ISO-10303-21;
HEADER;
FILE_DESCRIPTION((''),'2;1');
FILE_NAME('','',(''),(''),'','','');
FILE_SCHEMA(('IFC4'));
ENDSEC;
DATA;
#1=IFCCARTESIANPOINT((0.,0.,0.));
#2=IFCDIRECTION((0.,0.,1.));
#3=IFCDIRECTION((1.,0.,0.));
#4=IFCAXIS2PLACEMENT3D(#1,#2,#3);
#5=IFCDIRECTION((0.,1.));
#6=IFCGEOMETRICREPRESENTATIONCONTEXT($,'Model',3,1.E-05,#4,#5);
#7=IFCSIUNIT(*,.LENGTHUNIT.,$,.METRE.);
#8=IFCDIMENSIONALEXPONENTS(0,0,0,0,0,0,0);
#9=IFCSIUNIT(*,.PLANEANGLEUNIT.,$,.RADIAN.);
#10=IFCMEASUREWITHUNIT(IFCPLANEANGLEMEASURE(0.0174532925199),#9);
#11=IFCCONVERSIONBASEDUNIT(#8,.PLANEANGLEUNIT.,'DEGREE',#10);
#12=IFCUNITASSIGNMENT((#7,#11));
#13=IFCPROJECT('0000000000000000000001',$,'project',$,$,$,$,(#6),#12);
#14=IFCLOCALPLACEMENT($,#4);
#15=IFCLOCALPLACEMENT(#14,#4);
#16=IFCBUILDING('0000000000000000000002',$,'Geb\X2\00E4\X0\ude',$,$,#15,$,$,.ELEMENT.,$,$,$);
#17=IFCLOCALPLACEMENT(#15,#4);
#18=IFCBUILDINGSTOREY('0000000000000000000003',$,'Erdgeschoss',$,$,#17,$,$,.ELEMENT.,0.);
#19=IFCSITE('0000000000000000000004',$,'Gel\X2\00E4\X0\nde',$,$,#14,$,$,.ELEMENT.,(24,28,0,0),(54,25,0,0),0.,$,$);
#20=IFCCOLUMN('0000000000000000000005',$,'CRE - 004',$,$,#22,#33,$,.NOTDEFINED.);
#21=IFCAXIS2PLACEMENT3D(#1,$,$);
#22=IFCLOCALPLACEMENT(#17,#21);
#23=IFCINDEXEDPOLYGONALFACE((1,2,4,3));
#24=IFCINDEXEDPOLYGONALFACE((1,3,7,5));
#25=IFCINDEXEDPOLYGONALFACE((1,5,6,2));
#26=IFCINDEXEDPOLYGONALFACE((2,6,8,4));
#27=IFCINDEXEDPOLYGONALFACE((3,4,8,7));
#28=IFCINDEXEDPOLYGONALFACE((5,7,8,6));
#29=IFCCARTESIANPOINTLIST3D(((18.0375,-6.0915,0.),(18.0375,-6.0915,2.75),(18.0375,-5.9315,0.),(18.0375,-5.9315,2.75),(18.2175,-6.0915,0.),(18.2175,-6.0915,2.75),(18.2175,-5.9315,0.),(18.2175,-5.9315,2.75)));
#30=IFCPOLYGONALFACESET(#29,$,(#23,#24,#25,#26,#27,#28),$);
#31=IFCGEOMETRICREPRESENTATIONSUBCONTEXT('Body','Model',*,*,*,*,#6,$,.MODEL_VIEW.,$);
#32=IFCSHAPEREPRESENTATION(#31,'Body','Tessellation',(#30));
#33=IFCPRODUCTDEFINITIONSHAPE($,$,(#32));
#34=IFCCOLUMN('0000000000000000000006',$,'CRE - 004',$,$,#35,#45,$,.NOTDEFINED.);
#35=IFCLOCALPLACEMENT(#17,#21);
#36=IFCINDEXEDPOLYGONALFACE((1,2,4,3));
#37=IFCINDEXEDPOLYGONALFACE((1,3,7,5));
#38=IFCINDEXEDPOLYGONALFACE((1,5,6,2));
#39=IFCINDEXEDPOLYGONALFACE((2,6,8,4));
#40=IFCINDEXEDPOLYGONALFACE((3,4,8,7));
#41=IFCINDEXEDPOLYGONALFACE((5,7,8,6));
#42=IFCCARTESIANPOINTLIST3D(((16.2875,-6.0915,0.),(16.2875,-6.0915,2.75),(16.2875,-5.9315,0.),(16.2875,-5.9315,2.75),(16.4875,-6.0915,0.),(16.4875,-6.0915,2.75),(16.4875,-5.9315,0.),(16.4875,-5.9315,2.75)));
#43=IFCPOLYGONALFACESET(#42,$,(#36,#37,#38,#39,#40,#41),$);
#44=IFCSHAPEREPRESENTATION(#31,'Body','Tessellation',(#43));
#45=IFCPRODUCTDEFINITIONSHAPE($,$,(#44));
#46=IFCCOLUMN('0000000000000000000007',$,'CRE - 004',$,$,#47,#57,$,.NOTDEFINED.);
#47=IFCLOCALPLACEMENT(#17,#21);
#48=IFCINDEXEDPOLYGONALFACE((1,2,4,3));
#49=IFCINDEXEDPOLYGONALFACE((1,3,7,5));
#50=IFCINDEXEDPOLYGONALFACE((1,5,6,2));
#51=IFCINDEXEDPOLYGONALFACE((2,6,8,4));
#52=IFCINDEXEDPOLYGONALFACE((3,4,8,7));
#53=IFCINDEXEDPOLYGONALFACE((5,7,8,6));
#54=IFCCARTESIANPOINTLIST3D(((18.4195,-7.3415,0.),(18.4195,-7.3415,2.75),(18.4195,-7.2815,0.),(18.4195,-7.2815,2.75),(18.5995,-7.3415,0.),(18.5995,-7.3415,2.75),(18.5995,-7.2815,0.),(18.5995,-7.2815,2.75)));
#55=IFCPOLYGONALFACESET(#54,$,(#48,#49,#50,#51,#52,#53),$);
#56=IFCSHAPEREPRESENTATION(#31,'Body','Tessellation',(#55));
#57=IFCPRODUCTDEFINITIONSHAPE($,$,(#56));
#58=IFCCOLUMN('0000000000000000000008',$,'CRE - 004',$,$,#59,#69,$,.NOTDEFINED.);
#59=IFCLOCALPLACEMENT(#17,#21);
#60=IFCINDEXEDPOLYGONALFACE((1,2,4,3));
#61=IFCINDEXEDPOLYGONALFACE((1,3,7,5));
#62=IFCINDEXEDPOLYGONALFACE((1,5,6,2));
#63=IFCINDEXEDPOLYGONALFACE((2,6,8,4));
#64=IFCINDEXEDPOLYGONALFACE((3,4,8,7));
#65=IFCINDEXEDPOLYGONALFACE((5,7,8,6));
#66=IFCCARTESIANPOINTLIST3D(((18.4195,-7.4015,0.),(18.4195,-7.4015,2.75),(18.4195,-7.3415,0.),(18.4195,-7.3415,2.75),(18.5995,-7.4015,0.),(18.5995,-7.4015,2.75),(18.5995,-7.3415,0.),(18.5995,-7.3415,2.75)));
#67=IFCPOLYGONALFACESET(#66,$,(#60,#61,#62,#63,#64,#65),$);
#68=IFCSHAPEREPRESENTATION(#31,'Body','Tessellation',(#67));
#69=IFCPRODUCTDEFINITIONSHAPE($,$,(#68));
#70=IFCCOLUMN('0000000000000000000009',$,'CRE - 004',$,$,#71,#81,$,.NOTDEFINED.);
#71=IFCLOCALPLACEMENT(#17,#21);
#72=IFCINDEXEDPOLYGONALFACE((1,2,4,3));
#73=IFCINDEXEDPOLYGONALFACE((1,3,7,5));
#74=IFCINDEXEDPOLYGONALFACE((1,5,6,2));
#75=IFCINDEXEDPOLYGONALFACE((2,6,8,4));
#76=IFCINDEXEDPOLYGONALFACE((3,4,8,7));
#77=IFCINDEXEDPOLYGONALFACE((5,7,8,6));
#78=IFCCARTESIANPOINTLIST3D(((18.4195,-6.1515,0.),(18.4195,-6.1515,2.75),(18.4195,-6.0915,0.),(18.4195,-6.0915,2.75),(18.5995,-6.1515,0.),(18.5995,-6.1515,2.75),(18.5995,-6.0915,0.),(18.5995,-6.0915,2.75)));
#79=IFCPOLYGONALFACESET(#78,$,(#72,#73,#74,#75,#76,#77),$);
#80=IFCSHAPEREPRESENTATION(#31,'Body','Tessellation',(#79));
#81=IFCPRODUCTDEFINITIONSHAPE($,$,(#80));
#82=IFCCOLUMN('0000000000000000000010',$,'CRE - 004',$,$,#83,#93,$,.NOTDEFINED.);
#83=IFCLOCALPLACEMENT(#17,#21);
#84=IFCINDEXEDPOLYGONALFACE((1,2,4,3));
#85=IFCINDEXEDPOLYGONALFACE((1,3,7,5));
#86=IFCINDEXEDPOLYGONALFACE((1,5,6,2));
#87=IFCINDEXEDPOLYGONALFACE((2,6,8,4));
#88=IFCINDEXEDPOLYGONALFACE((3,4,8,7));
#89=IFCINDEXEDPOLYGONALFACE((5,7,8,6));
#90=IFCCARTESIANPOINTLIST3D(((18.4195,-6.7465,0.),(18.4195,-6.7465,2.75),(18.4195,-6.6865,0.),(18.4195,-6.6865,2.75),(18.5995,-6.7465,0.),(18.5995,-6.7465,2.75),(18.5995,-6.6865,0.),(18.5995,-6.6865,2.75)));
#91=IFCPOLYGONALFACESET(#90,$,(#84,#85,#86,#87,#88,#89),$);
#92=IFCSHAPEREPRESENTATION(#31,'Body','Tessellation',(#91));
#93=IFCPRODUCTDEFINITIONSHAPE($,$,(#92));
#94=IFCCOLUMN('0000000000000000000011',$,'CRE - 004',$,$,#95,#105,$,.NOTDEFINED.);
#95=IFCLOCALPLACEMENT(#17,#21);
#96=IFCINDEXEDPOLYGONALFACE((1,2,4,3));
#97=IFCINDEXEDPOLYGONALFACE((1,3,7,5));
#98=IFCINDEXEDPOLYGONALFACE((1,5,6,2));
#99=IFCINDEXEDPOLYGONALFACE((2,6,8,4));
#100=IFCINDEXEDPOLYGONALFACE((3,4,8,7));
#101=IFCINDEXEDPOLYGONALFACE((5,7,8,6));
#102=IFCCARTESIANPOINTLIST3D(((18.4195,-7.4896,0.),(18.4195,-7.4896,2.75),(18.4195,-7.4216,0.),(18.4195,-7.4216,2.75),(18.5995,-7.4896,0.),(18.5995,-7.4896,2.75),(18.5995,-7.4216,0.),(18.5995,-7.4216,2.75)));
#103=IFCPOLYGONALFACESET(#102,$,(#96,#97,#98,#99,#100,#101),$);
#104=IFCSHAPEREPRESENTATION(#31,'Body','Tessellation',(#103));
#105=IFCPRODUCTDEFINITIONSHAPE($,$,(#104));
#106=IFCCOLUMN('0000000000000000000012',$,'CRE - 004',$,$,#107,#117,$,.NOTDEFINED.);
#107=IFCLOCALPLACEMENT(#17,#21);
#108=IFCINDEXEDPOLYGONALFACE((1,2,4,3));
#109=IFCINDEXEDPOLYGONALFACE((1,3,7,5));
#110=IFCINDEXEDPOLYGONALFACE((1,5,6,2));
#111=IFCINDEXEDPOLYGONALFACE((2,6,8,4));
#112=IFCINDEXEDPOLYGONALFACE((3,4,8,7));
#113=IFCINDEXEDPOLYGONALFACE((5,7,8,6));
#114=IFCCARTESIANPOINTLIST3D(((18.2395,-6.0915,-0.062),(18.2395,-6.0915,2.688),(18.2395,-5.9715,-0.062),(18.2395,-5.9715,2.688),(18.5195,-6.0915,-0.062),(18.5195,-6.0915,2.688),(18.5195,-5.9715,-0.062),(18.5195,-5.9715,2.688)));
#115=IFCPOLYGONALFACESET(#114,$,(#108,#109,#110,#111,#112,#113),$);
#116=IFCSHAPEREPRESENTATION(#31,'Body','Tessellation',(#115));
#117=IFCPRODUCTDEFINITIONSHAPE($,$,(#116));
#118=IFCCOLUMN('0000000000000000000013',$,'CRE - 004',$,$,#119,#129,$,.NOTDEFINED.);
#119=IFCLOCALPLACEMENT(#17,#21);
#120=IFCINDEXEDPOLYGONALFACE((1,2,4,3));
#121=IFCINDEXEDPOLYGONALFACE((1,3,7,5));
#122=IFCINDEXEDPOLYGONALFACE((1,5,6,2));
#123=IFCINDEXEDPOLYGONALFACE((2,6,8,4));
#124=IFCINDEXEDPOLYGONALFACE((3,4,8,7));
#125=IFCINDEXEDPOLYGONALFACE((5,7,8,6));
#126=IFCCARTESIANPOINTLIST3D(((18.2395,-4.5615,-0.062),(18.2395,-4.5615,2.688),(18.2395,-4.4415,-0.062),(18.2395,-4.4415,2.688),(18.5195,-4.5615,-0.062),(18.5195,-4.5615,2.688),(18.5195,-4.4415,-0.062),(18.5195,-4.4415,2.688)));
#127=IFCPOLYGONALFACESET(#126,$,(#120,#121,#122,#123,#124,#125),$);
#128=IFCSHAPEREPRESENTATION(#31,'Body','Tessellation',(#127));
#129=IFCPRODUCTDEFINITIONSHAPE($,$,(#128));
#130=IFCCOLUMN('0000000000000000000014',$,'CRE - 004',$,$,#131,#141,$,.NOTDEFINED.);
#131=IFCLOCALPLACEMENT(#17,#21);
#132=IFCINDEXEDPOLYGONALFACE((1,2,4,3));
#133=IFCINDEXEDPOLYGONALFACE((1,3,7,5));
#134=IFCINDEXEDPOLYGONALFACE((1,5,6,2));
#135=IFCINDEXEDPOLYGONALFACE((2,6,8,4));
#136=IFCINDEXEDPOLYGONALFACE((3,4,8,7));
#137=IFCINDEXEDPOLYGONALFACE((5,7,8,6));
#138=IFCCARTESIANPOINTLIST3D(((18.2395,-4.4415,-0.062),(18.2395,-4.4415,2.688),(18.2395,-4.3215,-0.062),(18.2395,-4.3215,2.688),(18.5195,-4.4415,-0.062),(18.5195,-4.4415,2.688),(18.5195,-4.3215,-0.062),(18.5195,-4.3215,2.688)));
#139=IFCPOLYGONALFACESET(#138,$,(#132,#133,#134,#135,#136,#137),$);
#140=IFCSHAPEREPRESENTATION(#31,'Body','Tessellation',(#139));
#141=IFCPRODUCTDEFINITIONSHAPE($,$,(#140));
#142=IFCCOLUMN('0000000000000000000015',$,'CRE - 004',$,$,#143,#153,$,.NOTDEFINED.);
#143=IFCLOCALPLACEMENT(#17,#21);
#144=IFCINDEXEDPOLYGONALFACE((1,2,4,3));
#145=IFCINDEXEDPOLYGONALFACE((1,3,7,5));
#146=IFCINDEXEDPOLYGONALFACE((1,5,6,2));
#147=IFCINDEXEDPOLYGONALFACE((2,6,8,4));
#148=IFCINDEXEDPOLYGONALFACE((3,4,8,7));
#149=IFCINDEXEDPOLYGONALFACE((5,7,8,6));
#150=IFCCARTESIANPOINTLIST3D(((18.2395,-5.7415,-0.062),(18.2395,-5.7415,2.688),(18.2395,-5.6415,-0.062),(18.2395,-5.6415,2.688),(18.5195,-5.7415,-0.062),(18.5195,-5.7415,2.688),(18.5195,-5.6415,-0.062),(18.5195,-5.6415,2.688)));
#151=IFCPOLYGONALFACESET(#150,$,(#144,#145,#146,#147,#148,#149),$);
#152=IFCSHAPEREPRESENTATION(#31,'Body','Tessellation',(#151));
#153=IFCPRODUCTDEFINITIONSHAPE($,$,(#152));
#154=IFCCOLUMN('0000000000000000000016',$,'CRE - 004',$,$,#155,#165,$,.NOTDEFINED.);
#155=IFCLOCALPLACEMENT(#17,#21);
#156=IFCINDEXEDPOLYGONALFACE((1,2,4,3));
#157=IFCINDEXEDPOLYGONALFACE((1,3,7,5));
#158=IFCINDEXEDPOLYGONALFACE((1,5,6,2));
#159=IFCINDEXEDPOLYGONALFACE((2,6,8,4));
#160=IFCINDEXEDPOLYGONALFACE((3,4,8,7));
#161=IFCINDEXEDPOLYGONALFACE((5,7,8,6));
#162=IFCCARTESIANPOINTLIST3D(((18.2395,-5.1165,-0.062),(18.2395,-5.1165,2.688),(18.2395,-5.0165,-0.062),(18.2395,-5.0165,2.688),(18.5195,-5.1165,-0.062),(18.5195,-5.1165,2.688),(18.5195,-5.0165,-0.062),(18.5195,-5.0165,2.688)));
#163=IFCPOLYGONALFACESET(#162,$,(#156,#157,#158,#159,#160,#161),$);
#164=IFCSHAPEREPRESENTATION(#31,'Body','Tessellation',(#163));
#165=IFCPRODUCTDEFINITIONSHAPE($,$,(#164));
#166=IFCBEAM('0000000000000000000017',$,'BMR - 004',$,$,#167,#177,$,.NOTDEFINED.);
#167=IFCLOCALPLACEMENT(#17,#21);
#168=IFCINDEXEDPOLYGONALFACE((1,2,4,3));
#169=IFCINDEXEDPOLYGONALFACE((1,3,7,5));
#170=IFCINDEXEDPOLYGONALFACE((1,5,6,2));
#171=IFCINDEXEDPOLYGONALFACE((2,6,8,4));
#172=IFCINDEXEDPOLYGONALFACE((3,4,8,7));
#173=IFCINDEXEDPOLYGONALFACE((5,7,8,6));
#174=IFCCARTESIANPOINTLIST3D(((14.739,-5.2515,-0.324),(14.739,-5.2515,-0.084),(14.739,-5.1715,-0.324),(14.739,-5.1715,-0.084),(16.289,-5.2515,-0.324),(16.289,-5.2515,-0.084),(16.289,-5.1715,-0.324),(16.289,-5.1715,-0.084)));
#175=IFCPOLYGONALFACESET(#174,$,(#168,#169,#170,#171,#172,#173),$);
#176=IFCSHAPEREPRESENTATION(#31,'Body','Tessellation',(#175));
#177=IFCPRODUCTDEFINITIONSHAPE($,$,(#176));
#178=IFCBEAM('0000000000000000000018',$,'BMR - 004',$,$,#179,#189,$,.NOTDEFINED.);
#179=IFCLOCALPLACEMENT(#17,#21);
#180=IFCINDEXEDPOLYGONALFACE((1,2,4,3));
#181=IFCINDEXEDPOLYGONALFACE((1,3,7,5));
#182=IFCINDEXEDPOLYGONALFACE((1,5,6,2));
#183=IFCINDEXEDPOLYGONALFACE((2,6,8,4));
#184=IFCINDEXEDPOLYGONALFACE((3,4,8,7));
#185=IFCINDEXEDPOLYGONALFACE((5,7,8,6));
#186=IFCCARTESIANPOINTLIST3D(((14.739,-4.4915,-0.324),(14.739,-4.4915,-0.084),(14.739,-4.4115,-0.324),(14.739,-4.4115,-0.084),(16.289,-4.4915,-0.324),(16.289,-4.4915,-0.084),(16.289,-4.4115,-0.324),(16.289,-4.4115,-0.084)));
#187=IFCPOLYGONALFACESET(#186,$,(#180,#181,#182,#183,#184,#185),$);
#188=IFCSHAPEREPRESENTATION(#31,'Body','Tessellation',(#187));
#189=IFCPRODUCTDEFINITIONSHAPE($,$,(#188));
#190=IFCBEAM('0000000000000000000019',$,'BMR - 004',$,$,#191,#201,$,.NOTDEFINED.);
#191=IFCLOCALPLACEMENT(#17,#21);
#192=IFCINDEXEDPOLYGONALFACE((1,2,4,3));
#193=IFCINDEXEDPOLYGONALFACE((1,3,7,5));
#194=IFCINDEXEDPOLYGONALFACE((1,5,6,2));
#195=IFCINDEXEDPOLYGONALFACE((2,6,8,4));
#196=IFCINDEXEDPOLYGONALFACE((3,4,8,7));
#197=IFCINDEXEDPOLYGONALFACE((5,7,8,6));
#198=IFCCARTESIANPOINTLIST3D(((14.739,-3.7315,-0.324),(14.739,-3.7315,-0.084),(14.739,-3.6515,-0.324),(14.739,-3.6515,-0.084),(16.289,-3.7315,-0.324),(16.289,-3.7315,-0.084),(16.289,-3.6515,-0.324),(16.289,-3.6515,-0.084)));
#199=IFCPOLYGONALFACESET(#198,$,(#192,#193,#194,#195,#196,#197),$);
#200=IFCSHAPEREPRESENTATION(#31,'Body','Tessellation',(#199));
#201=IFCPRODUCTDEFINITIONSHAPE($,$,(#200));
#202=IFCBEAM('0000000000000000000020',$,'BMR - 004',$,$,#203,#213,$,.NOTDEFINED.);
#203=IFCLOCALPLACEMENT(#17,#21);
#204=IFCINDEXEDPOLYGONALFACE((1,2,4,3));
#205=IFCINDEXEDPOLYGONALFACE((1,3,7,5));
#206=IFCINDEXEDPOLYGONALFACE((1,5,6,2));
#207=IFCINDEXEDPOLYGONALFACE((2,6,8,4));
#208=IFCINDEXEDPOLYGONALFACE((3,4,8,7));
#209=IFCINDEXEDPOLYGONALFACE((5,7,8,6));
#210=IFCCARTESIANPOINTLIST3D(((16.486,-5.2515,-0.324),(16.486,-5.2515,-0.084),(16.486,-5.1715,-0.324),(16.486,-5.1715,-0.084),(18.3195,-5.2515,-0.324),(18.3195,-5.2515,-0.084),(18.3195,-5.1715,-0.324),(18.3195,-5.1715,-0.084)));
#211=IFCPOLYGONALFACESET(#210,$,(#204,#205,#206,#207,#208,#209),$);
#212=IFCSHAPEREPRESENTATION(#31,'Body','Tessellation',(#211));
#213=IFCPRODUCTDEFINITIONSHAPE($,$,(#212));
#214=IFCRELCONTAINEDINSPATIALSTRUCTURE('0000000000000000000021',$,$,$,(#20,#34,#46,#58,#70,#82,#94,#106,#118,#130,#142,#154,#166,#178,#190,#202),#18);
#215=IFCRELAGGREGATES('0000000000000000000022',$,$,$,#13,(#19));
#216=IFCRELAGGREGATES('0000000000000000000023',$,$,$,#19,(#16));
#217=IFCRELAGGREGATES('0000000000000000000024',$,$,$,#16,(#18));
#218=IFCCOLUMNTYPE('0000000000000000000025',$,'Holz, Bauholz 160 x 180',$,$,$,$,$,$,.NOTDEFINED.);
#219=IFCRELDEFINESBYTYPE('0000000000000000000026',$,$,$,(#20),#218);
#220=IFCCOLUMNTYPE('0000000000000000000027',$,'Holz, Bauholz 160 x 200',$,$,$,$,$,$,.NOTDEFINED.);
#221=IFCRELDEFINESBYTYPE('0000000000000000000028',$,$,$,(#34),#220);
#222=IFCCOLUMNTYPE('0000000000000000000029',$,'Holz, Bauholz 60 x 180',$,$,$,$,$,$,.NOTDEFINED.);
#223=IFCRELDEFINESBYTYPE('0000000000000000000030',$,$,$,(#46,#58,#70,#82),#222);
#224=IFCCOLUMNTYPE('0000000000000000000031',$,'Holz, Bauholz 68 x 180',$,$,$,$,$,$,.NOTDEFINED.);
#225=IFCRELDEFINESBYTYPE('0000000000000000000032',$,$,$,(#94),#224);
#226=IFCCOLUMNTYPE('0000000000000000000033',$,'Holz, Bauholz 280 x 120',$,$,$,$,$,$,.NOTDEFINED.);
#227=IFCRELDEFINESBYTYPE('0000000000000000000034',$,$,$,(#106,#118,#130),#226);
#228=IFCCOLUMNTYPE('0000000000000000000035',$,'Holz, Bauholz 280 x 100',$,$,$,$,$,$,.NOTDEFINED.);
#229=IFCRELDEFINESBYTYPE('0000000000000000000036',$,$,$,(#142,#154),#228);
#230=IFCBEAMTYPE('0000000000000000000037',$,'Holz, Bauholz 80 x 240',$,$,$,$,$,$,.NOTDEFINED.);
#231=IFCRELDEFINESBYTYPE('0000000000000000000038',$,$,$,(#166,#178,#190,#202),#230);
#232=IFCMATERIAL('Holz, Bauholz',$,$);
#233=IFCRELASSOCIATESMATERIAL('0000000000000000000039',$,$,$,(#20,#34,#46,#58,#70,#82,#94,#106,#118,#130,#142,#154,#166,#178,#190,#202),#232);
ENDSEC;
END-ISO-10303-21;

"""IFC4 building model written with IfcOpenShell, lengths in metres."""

from ifc_helpers import new_model, entity, si_unit, converted_unit, direction, frame, frame_2d, origin_with_axes, origin_2d_with_axis, place, context, subcontext, project, spatial, rectangle, extrude, material, type_object, element, save


model = new_model("IFC4")

# Units and contexts
model_context = context("Model", 3, precision=1e-05, world=origin_with_axes(), true_north=direction((0.0, 1.0)))
body_context = subcontext(model_context, "Body", "Model", "MODEL_VIEW")
ifc_project = project(units=[si_unit("LENGTHUNIT", "METRE"), converted_unit("PLANEANGLEUNIT", "DEGREE", entity("IfcPlaneAngleMeasure", 0.0174532925199), si_unit("PLANEANGLEUNIT", "RADIAN"), dimensions=[0, 0, 0, 0, 0, 0, 0])], contexts=[model_context])

# Site, building, storey
site_placement = place(None, origin_with_axes())
site = spatial("IfcSite", under=ifc_project, at=site_placement, Name="Gelände", CompositionType="ELEMENT", RefLatitude=(24, 28, 0, 0), RefLongitude=(54, 25, 0, 0), RefElevation=0.0)
building_placement = place(site_placement, origin_with_axes())
building = spatial("IfcBuilding", under=site, at=building_placement, Name="Gebäude", CompositionType="ELEMENT")
storey_placement = place(building_placement, origin_with_axes())
storey = spatial("IfcBuildingStorey", under=building, at=storey_placement, Name="Erdgeschoss", CompositionType="ELEMENT", Elevation=0.0)

# Columns
ifc_material_1 = material(Name="Holz, Bauholz")
column_type_1 = type_object("IfcColumnType", Name="Holz, Bauholz 160 x 180", PredefinedType="NOTDEFINED")
column_1_placement = place(storey_placement, frame((18.1275, -6.0115, 0.0), z_axis=(0.0, 0.0, 1.0), x_axis=(1.0, 0.0, 0.0)))
element("IfcColumn", 1, at=column_1_placement, inside=storey, type_object=column_type_1, material=ifc_material_1, Name="CRE - 004", PredefinedType="NOTDEFINED", context=body_context, shape_type="SweptSolid", body=[
    extrude(rectangle(XDim=0.16, YDim=0.18, at=origin_2d_with_axis()), frame((0.0, 0.0, 0.0), z_axis=(0.0, 0.0, 1.0), x_axis=(0.0, 1.0, 0.0)), (0.0, 0.0, 1.0), 2.75),
])
column_type_2 = type_object("IfcColumnType", Name="Holz, Bauholz 160 x 200", PredefinedType="NOTDEFINED")
column_2_placement = place(storey_placement, frame((16.3875, -6.0115, 0.0), z_axis=(0.0, 0.0, 1.0), x_axis=(1.0, 0.0, 0.0)))
element("IfcColumn", 2, at=column_2_placement, inside=storey, type_object=column_type_2, material=ifc_material_1, Name="CRE - 004", PredefinedType="NOTDEFINED", context=body_context, shape_type="SweptSolid", body=[
    extrude(rectangle(XDim=0.16, YDim=0.2, at=origin_2d_with_axis()), frame((0.0, 0.0, 0.0), z_axis=(0.0, 0.0, 1.0), x_axis=(0.0, 1.0, 0.0)), (0.0, 0.0, 1.0), 2.75),
])
column_type_3 = type_object("IfcColumnType", Name="Holz, Bauholz 60 x 180", PredefinedType="NOTDEFINED")
for number, where, z_axis, x_axis, name in (
    (3, (18.5095, -7.3115, 0.0), (0.0, 0.0, 1.0), (1.0, 0.0, 0.0), "CRE - 004"),
    (4, (18.5095, -7.3715, 0.0), (0.0, 0.0, 1.0), (1.0, 0.0, 0.0), "CRE - 004"),
    (5, (18.5095, -6.1215, 0.0), (0.0, 0.0, 1.0), (1.0, 0.0, 0.0), "CRE - 004"),
    (6, (18.5095, -6.7165, 0.0), (0.0, 0.0, 1.0), (1.0, 0.0, 0.0), "CRE - 004"),
):
    element("IfcColumn", number, at=place(storey_placement, frame(where, z_axis=z_axis, x_axis=x_axis)), inside=storey, type_object=column_type_3, material=ifc_material_1, Name=name, PredefinedType="NOTDEFINED", context=body_context, shape_type="SweptSolid", body=[
        extrude(rectangle(XDim=0.06, YDim=0.18, at=origin_2d_with_axis()), frame((0.0, 0.0, 0.0), z_axis=(0.0, 0.0, 1.0), x_axis=(0.0, 1.0, 0.0)), (0.0, 0.0, 1.0), 2.75),
    ])
column_type_4 = type_object("IfcColumnType", Name="Holz, Bauholz 68 x 180", PredefinedType="NOTDEFINED")
column_3_placement = place(storey_placement, frame((18.5095, -7.4556, 0.0), z_axis=(0.0, 0.0, 1.0), x_axis=(1.0, 0.0, 0.0)))
element("IfcColumn", 7, at=column_3_placement, inside=storey, type_object=column_type_4, material=ifc_material_1, Name="CRE - 004", PredefinedType="NOTDEFINED", context=body_context, shape_type="SweptSolid", body=[
    extrude(rectangle(XDim=0.068, YDim=0.18, at=origin_2d_with_axis()), frame((0.0, 0.0, 0.0), z_axis=(0.0, 0.0, 1.0), x_axis=(0.0, 1.0, 0.0)), (0.0, 0.0, 1.0), 2.75),
])
column_type_5 = type_object("IfcColumnType", Name="Holz, Bauholz 280 x 120", PredefinedType="NOTDEFINED")
for number, where, z_axis, x_axis, name in (
    (8, (18.3795, -6.0315, -0.062), (0.0, 0.0, 1.0), (0.0, 1.0, 0.0), "CRE - 004"),
    (9, (18.3795, -4.5015, -0.062), (0.0, 0.0, 1.0), (0.0, 1.0, 0.0), "CRE - 004"),
    (10, (18.3795, -4.3815, -0.062), (0.0, 0.0, 1.0), (0.0, 1.0, 0.0), "CRE - 004"),
):
    element("IfcColumn", number, at=place(storey_placement, frame(where, z_axis=z_axis, x_axis=x_axis)), inside=storey, type_object=column_type_5, material=ifc_material_1, Name=name, PredefinedType="NOTDEFINED", context=body_context, shape_type="SweptSolid", body=[
        extrude(rectangle(XDim=0.28, YDim=0.12, at=origin_2d_with_axis()), frame((0.0, 0.0, 0.0), z_axis=(0.0, 0.0, 1.0), x_axis=(0.0, 1.0, 0.0)), (0.0, 0.0, 1.0), 2.75),
    ])
column_type_6 = type_object("IfcColumnType", Name="Holz, Bauholz 280 x 100", PredefinedType="NOTDEFINED")
for number, where, z_axis, x_axis, name in (
    (11, (18.3795, -5.6915, -0.062), (0.0, 0.0, 1.0), (0.0, 1.0, 0.0), "CRE - 004"),
    (12, (18.3795, -5.0665, -0.062), (0.0, 0.0, 1.0), (0.0, 1.0, 0.0), "CRE - 004"),
):
    element("IfcColumn", number, at=place(storey_placement, frame(where, z_axis=z_axis, x_axis=x_axis)), inside=storey, type_object=column_type_6, material=ifc_material_1, Name=name, PredefinedType="NOTDEFINED", context=body_context, shape_type="SweptSolid", body=[
        extrude(rectangle(XDim=0.28, YDim=0.1, at=origin_2d_with_axis()), frame((0.0, 0.0, 0.0), z_axis=(0.0, 0.0, 1.0), x_axis=(0.0, 1.0, 0.0)), (0.0, 0.0, 1.0), 2.75),
    ])

# Beams
beam_type_1 = type_object("IfcBeamType", Name="Holz, Bauholz 80 x 240", PredefinedType="NOTDEFINED")
for number, where, z_axis, x_axis, name in (
    (13, (16.289, -5.2115, -0.084), (0.0, 0.0, 1.0), (0.0, 1.0, 0.0), "BMR - 004"),
    (14, (16.289, -4.4515, -0.084), (0.0, 0.0, 1.0), (0.0, 1.0, 0.0), "BMR - 004"),
    (15, (16.289, -3.6915, -0.084), (0.0, 0.0, 1.0), (0.0, 1.0, 0.0), "BMR - 004"),
):
    element("IfcBeam", number, at=place(storey_placement, frame(where, z_axis=z_axis, x_axis=x_axis)), inside=storey, type_object=beam_type_1, material=ifc_material_1, Name=name, PredefinedType="NOTDEFINED", context=body_context, shape_type="SweptSolid", body=[
        extrude(rectangle(XDim=0.24, YDim=0.08, at=frame_2d((-0.12, 0.0), x_axis=(1.0, 0.0))), frame((0.0, 0.0, 0.0), z_axis=(0.0, 1.0, 0.0), x_axis=(0.0, 0.0, 1.0)), (0.0, 0.0, 1.0), 1.55),
    ])
for number, where, z_axis, x_axis, name in (
    (16, (18.3195, -5.2115, -0.084), (0.0, 0.0, 1.0), (0.0, 1.0, 0.0), "BMR - 004"),
):
    element("IfcBeam", number, at=place(storey_placement, frame(where, z_axis=z_axis, x_axis=x_axis)), inside=storey, type_object=beam_type_1, material=ifc_material_1, Name=name, PredefinedType="NOTDEFINED", context=body_context, shape_type="SweptSolid", body=[
        extrude(rectangle(XDim=0.24, YDim=0.08, at=frame_2d((-0.12, 0.0), x_axis=(1.0, 0.0))), frame((0.0, 0.0, 0.0), z_axis=(0.0, 1.0, 0.0), x_axis=(0.0, 0.0, 1.0)), (0.0, 0.0, 1.0), 1.8335),
    ])

save(model, "model.ifc")
